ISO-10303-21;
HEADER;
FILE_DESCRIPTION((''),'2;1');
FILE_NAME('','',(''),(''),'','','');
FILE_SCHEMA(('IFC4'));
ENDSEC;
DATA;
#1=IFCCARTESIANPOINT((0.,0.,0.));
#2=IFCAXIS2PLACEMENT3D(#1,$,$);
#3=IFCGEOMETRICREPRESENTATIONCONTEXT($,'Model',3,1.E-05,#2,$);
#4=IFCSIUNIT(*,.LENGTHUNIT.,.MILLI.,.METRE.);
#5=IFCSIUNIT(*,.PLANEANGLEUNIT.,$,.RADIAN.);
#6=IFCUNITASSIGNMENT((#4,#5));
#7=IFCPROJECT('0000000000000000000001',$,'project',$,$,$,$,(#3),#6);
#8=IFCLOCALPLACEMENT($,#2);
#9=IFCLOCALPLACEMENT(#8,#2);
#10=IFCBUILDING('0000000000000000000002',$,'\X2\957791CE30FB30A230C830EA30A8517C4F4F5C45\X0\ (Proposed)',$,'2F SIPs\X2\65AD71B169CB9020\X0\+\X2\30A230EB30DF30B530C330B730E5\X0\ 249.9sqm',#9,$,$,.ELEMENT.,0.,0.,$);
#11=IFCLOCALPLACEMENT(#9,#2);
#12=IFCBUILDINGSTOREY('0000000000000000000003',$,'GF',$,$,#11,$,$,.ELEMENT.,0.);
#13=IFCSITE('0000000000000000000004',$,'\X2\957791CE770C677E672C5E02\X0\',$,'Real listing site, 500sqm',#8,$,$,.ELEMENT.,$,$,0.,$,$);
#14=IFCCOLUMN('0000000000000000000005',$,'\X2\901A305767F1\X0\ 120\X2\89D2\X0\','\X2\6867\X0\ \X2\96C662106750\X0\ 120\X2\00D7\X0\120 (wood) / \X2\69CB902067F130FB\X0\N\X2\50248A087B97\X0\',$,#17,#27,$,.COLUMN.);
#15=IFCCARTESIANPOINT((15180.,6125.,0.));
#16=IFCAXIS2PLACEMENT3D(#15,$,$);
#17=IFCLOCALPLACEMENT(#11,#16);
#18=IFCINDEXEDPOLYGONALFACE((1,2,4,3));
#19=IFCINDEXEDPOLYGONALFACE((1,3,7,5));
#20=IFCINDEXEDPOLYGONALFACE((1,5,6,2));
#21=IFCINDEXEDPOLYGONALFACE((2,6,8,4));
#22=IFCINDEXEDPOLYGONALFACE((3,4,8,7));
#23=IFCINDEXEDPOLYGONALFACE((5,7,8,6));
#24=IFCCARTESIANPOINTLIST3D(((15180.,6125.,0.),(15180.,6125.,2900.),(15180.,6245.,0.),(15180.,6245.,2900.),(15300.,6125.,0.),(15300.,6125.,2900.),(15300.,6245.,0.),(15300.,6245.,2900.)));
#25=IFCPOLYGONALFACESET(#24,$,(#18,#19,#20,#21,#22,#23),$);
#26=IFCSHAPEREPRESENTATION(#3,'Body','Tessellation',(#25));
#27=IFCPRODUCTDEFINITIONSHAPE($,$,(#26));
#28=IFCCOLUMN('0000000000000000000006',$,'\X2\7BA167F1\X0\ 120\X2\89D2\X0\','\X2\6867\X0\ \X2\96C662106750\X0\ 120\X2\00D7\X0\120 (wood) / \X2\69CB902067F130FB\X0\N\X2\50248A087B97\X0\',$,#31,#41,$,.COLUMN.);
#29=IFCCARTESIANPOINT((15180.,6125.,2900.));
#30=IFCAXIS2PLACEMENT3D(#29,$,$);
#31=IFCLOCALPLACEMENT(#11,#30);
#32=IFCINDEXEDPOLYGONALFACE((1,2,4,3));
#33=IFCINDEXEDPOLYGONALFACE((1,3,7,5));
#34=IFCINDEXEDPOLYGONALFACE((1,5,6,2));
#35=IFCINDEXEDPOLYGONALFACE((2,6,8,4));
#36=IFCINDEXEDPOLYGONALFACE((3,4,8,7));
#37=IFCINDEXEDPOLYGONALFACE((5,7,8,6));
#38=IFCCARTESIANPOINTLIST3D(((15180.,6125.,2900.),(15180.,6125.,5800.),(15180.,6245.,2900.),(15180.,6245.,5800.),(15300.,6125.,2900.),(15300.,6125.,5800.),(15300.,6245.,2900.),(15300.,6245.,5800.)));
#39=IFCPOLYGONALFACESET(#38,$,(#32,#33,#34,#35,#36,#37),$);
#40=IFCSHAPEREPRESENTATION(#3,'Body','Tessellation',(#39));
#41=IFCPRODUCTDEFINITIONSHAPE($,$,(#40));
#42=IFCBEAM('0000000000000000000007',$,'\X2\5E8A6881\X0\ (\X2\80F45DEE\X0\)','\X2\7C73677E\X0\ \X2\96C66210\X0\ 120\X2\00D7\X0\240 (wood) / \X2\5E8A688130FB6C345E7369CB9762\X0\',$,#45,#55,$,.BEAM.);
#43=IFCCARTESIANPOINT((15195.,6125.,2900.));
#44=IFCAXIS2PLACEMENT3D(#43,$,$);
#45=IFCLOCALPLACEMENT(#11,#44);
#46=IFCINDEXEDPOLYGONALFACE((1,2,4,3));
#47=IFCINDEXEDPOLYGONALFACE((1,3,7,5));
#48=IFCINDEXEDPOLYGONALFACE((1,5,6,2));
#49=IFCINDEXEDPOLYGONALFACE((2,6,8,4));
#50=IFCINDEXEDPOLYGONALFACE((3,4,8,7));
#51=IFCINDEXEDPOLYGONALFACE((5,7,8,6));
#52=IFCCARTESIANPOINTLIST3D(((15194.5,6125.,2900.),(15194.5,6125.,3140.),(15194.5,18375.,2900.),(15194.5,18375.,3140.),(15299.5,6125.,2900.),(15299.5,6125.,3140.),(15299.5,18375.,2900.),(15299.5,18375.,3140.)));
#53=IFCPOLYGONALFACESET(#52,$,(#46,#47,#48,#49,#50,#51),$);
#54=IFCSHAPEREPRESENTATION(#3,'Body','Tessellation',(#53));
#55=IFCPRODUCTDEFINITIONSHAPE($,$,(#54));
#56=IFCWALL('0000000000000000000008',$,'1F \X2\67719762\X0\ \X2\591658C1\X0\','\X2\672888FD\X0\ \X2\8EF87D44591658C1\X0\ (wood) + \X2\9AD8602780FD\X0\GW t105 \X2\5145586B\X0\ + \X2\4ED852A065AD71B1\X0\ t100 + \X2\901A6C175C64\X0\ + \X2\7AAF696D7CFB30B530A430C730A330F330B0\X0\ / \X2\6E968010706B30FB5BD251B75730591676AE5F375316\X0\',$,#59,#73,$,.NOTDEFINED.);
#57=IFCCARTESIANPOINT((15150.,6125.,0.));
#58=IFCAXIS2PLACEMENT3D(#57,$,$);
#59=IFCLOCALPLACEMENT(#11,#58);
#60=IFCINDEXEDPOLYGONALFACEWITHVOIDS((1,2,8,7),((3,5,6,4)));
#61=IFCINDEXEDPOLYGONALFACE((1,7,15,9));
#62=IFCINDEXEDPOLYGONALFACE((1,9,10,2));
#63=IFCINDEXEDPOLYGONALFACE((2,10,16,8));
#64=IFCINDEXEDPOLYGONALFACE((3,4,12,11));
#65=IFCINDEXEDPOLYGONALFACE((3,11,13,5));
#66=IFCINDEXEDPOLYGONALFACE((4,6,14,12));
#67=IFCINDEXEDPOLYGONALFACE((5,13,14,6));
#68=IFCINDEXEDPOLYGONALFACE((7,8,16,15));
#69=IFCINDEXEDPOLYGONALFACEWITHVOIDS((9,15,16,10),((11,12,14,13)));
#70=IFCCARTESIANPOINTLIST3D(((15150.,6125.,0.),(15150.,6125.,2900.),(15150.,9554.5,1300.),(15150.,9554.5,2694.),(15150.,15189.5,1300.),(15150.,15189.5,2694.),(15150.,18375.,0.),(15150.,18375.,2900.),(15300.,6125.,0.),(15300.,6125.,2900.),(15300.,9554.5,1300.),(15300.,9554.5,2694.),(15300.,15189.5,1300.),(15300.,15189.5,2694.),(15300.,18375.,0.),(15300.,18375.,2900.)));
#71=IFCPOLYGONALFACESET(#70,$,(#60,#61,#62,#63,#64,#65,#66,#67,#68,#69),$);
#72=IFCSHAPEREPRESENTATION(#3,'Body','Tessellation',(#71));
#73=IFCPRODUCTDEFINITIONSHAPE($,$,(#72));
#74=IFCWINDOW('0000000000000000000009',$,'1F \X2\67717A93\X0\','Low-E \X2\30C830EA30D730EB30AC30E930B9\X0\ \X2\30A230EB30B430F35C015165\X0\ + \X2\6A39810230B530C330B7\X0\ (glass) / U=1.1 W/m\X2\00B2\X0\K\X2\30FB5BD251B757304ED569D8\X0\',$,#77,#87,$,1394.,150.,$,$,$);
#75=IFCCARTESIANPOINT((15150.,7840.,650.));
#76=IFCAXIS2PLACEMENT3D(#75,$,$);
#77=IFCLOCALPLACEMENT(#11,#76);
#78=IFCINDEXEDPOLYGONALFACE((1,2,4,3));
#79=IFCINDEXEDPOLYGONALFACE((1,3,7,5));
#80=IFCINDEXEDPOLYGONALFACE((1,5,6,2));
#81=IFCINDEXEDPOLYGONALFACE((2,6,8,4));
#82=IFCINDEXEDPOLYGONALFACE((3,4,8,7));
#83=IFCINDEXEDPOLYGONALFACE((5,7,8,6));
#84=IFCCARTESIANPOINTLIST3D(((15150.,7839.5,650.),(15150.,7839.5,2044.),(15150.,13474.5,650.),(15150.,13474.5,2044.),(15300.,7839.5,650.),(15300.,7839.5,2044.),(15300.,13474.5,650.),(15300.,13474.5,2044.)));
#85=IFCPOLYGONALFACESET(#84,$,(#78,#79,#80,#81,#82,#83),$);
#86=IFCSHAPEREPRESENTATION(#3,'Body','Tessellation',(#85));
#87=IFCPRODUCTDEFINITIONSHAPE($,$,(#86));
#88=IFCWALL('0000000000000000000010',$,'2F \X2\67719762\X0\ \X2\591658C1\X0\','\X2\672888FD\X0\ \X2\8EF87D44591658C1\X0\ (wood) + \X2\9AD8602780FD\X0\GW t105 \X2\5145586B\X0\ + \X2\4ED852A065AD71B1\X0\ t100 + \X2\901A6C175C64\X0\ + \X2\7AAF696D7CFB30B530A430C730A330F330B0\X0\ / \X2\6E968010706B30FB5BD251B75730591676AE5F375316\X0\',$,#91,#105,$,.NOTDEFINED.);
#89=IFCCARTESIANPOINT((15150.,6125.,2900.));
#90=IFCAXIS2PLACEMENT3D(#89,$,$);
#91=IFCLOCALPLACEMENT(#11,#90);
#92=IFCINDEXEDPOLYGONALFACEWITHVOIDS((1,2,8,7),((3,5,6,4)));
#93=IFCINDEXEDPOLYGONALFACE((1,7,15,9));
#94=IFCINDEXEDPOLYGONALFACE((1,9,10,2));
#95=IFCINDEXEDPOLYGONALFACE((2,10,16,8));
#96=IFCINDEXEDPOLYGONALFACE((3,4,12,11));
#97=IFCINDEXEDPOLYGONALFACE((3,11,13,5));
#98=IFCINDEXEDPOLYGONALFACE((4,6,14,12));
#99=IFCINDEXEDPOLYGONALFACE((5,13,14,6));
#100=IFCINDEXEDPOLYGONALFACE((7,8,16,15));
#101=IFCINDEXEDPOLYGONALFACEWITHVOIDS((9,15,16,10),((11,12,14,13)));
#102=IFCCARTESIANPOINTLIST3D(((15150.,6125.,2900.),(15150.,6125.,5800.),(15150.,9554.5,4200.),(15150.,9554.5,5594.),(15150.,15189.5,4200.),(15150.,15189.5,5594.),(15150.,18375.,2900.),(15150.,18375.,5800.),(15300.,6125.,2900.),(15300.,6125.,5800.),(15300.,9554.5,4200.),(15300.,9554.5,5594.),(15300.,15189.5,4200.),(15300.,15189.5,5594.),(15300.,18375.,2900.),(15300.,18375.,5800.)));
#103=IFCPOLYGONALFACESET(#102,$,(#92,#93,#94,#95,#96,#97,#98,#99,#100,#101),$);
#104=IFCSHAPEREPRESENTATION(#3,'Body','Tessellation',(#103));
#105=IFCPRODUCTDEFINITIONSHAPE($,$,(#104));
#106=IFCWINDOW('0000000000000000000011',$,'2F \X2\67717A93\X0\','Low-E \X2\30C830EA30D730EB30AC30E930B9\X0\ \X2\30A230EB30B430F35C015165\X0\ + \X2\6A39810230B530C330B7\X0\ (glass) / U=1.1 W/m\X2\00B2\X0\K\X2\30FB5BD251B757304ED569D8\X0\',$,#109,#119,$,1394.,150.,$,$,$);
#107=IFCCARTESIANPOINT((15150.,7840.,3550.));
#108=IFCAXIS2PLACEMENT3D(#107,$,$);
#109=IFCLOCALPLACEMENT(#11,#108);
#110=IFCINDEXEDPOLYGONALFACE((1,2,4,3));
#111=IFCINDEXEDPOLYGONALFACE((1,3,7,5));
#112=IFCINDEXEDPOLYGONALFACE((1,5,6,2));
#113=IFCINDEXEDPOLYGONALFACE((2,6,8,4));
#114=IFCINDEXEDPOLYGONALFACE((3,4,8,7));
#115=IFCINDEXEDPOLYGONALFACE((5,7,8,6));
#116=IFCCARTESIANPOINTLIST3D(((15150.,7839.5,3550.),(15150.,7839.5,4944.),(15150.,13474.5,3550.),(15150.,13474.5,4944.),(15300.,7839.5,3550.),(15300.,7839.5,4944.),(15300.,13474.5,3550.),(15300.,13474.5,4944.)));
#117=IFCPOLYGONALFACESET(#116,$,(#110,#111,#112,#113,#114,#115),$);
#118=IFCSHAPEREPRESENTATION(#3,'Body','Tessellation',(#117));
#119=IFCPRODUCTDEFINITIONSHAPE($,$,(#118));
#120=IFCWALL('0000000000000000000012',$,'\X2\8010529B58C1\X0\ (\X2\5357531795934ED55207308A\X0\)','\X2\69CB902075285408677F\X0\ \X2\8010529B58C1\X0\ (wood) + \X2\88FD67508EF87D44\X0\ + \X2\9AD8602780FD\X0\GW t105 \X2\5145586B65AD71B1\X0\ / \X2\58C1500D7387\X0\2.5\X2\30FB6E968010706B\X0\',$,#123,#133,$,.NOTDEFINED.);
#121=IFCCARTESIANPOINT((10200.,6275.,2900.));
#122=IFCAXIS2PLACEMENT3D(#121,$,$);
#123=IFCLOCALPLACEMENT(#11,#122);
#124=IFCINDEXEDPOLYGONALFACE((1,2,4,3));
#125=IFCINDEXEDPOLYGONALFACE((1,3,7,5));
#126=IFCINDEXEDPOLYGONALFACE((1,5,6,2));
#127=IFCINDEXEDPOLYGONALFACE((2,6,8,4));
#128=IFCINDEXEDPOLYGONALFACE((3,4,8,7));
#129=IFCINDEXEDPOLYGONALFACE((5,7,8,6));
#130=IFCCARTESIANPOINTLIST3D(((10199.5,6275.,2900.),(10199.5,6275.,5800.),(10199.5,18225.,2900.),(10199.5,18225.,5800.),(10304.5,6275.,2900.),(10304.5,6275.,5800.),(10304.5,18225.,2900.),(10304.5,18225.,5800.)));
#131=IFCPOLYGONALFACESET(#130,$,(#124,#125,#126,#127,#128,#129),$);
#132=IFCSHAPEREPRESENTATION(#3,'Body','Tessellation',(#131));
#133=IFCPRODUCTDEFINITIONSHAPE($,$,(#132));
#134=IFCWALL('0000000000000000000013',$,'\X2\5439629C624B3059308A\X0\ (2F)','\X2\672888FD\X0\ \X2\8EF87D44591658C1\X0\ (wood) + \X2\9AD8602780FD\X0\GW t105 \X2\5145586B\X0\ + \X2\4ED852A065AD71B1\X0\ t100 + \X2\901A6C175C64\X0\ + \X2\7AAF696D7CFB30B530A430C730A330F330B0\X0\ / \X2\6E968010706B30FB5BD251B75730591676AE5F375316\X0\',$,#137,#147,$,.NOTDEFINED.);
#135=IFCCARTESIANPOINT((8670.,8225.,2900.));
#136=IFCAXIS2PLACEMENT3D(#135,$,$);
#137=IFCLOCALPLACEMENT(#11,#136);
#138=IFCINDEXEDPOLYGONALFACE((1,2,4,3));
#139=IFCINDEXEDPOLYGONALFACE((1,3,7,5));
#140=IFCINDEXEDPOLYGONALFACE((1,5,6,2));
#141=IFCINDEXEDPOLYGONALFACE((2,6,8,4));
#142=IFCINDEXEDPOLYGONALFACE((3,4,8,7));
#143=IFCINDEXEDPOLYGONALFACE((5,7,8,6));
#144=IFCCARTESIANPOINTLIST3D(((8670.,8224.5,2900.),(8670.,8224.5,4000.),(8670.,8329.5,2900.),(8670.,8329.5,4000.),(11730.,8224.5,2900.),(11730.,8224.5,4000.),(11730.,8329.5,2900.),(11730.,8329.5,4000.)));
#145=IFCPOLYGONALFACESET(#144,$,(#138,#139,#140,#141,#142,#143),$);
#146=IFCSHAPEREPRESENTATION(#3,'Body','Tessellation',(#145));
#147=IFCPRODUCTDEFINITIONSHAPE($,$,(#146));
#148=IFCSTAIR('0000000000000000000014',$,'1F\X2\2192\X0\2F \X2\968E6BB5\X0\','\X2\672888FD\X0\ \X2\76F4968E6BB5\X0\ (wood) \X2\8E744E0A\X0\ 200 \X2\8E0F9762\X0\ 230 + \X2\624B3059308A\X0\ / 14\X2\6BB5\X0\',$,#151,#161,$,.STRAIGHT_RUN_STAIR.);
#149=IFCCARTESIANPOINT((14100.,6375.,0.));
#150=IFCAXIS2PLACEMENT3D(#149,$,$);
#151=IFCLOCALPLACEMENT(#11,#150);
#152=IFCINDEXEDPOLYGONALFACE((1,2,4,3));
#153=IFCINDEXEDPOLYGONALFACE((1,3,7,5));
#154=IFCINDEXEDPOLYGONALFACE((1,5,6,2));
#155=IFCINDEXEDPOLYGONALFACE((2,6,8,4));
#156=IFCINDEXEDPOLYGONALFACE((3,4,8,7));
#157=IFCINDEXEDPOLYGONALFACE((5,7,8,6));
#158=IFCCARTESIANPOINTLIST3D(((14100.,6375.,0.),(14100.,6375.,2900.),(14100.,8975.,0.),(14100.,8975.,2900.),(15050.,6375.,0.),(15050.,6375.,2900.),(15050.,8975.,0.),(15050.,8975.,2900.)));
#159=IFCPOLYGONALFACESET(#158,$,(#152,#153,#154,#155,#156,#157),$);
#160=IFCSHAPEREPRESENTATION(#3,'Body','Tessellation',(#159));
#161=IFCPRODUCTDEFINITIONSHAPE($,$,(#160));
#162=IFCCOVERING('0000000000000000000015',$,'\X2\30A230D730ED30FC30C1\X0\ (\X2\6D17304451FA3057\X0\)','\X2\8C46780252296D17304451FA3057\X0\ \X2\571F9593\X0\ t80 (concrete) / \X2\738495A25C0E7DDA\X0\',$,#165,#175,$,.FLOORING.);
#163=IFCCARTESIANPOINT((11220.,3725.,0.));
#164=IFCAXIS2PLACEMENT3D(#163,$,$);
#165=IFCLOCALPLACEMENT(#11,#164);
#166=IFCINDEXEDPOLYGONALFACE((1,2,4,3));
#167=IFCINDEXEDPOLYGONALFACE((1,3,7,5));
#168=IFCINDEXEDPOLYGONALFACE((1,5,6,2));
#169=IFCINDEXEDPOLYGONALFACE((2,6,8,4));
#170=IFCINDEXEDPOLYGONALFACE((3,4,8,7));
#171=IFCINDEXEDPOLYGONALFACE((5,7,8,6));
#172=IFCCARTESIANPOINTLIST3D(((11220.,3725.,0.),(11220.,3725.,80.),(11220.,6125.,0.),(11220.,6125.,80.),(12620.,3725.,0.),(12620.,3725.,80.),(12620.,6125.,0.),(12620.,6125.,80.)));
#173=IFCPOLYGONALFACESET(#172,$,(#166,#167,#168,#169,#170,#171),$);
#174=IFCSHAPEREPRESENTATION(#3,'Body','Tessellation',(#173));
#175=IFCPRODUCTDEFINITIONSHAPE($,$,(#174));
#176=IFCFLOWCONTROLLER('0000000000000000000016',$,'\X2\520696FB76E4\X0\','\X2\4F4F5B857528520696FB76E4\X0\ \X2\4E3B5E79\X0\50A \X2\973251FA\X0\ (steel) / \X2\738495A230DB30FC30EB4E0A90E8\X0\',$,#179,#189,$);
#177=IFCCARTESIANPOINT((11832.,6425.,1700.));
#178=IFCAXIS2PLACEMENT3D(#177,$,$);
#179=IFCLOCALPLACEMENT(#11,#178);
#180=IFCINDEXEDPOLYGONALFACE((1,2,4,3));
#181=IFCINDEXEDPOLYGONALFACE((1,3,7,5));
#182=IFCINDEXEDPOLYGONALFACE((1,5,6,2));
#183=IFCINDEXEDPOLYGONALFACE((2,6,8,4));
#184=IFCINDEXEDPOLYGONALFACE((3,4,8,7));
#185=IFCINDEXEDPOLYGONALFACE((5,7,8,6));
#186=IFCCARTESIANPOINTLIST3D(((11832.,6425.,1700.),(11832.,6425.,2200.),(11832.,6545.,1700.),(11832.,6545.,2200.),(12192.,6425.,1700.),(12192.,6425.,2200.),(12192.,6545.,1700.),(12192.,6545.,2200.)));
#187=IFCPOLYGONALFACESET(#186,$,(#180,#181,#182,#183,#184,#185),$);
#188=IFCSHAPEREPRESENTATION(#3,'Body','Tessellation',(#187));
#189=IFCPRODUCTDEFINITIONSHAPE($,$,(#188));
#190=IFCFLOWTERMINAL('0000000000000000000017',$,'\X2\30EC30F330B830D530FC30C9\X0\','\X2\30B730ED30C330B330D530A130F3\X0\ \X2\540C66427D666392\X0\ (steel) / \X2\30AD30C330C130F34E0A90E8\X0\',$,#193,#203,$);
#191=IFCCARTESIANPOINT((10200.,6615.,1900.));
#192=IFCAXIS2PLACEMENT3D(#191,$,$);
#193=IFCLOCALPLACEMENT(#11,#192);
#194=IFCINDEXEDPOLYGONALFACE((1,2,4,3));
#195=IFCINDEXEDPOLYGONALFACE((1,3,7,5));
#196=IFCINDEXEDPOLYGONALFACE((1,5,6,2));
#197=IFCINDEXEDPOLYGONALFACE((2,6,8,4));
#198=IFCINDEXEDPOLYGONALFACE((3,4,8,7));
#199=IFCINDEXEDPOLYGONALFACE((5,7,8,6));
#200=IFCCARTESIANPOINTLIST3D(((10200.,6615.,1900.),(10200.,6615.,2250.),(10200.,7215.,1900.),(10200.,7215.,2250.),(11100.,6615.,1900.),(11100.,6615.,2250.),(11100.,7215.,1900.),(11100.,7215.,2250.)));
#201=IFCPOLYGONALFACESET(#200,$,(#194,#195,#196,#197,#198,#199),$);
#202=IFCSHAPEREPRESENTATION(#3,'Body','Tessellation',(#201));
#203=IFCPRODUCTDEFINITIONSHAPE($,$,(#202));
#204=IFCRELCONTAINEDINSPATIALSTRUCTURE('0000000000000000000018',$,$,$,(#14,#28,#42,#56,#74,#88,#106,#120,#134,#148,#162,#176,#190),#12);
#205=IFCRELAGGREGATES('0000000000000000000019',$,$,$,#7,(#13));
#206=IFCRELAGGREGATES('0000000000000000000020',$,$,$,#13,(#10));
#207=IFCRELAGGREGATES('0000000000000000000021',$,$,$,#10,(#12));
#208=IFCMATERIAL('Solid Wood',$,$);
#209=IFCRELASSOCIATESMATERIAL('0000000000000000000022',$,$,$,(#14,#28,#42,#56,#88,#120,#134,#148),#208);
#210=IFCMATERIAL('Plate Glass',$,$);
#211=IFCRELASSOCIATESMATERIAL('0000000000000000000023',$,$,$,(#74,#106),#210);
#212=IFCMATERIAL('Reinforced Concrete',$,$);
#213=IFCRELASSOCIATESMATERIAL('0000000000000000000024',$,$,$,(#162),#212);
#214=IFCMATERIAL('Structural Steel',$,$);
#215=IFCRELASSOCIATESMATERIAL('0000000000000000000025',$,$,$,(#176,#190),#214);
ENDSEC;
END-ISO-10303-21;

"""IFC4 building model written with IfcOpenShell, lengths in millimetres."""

from ifc_helpers import new_model, si_unit, frame, frame_2d, origin, place, context, project, spatial, rectangle, extrude, material, element, fill, save


model = new_model("IFC4")

# Units and contexts
model_context = context("Model", 3, precision=1e-05, world=origin())
ifc_project = project(units=[si_unit("LENGTHUNIT", "METRE", prefix="MILLI"), si_unit("PLANEANGLEUNIT", "RADIAN")], contexts=[model_context])

# Site, building, storey
site_placement = place(None, origin())
site = spatial("IfcSite", under=ifc_project, at=site_placement, Name="長野県松本市", ObjectType="Real listing site, 500sqm", CompositionType="ELEMENT", RefElevation=0.0)
building_placement = place(site_placement, origin())
building = spatial("IfcBuilding", under=site, at=building_placement, Name="長野・アトリエ兼住居 (Proposed)", ObjectType="2F SIPs断熱構造+アルミサッシュ 249.9sqm", CompositionType="ELEMENT", ElevationOfRefHeight=0.0, ElevationOfTerrain=0.0)
storey_placement = place(building_placement, origin())
storey = spatial("IfcBuildingStorey", under=building, at=storey_placement, Name="GF", CompositionType="ELEMENT", Elevation=0.0)

# Columns
ifc_material_1 = material(Name="Solid Wood")
column_1_placement = place(storey_placement, frame((15180.0, 6125.0, 0.0)))
element("IfcColumn", 1, at=column_1_placement, inside=storey, material=ifc_material_1, Name="通し柱 120角", Description="桧 集成材 120×120 (wood) / 構造柱・N値計算", PredefinedType="COLUMN", context=model_context, shape_type="SweptSolid", body=[
    extrude(rectangle(XDim=120.0, YDim=120.0, at=frame_2d((60.0, 60.0))), frame((15180.0, 6125.0, 0.0)), (0.0, 0.0, 1.0), 2900.0),
])
column_2_placement = place(storey_placement, frame((15180.0, 6125.0, 2900.0)))
element("IfcColumn", 2, at=column_2_placement, inside=storey, material=ifc_material_1, Name="管柱 120角", Description="桧 集成材 120×120 (wood) / 構造柱・N値計算", PredefinedType="COLUMN", context=model_context, shape_type="SweptSolid", body=[
    extrude(rectangle(XDim=120.0, YDim=120.0, at=frame_2d((60.0, 60.0))), frame((15180.0, 6125.0, 2900.0)), (0.0, 0.0, 1.0), 2900.0),
])

# Beam
beam_1_placement = place(storey_placement, frame((15195.0, 6125.0, 2900.0)))
element("IfcBeam", 3, at=beam_1_placement, inside=storey, material=ifc_material_1, Name="床梁 (胴差)", Description="米松 集成 120×240 (wood) / 床梁・水平構面", PredefinedType="BEAM", context=model_context, shape_type="SweptSolid", body=[
    extrude(rectangle(XDim=105.0, YDim=12250.0, at=frame_2d((52.0, 6125.0))), frame((15195.0, 6125.0, 2900.0)), (0.0, 0.0, 1.0), 240.0),
])

# Wall, opening, window
wall_1_placement = place(storey_placement, frame((15150.0, 6125.0, 0.0)))
wall_1 = element("IfcWall", 4, at=wall_1_placement, inside=storey, material=ifc_material_1, Name="1F 東面 外壁", Description="木製 軸組外壁 (wood) + 高性能GW t105 充填 + 付加断熱 t100 + 通気層 + 窯業系サイディング / 準耐火・寒冷地外皮強化", PredefinedType="NOTDEFINED", context=model_context, shape_type="SweptSolid", body=[
    extrude(rectangle(XDim=150.0, YDim=12250.0, at=frame_2d((75.0, 6125.0))), frame((15150.0, 6125.0, 0.0)), (0.0, 0.0, 1.0), 2900.0),
])
opening_1_placement = place(storey_placement, frame((15150.0, 7840.0, 650.0)))
opening_1 = element("IfcOpeningElement", 5, at=opening_1_placement, cuts=wall_1, PredefinedType="NOTDEFINED", context=model_context, shape_type="SweptSolid", body=[
    extrude(rectangle(XDim=150.0, YDim=5635.0, at=frame_2d((75.0, 2817.0))), frame((15150.0, 7840.0, 650.0)), (0.0, 0.0, 1.0), 1394.0),
])
ifc_material_2 = material(Name="Plate Glass")
window_1_placement = place(storey_placement, frame((15150.0, 7840.0, 650.0)))
window_1 = element("IfcWindow", 6, at=window_1_placement, inside=storey, material=ifc_material_2, Name="1F 東窓", Description="Low-E トリプルガラス アルゴン封入 + 樹脂サッシ (glass) / U=1.1 W/m²K・寒冷地仕様", OverallHeight=1394.0, OverallWidth=150.0, context=model_context, shape_type="SweptSolid", body=[
    extrude(rectangle(XDim=150.0, YDim=5635.0, at=frame_2d((75.0, 2817.0))), frame((15150.0, 7840.0, 650.0)), (0.0, 0.0, 1.0), 1394.0),
])
fill(opening_1, window_1)

# Wall, opening, window
wall_2_placement = place(storey_placement, frame((15150.0, 6125.0, 2900.0)))
wall_2 = element("IfcWall", 7, at=wall_2_placement, inside=storey, material=ifc_material_1, Name="2F 東面 外壁", Description="木製 軸組外壁 (wood) + 高性能GW t105 充填 + 付加断熱 t100 + 通気層 + 窯業系サイディング / 準耐火・寒冷地外皮強化", PredefinedType="NOTDEFINED", context=model_context, shape_type="SweptSolid", body=[
    extrude(rectangle(XDim=150.0, YDim=12250.0, at=frame_2d((75.0, 6125.0))), frame((15150.0, 6125.0, 2900.0)), (0.0, 0.0, 1.0), 2900.0),
])
opening_2_placement = place(storey_placement, frame((15150.0, 7840.0, 3550.0)))
opening_2 = element("IfcOpeningElement", 8, at=opening_2_placement, cuts=wall_2, PredefinedType="NOTDEFINED", context=model_context, shape_type="SweptSolid", body=[
    extrude(rectangle(XDim=150.0, YDim=5635.0, at=frame_2d((75.0, 2817.0))), frame((15150.0, 7840.0, 3550.0)), (0.0, 0.0, 1.0), 1394.0),
])
window_2_placement = place(storey_placement, frame((15150.0, 7840.0, 3550.0)))
window_2 = element("IfcWindow", 9, at=window_2_placement, inside=storey, material=ifc_material_2, Name="2F 東窓", Description="Low-E トリプルガラス アルゴン封入 + 樹脂サッシ (glass) / U=1.1 W/m²K・寒冷地仕様", OverallHeight=1394.0, OverallWidth=150.0, context=model_context, shape_type="SweptSolid", body=[
    extrude(rectangle(XDim=150.0, YDim=5635.0, at=frame_2d((75.0, 2817.0))), frame((15150.0, 7840.0, 3550.0)), (0.0, 0.0, 1.0), 1394.0),
])
fill(opening_2, window_2)

# Walls
wall_3_placement = place(storey_placement, frame((10200.0, 6275.0, 2900.0)))
element("IfcWall", 10, at=wall_3_placement, inside=storey, material=ifc_material_1, Name="耐力壁 (南北間仕切り)", Description="構造用合板 耐力壁 (wood) + 製材軸組 + 高性能GW t105 充填断熱 / 壁倍率2.5・準耐火", PredefinedType="NOTDEFINED", context=model_context, shape_type="SweptSolid", body=[
    extrude(rectangle(XDim=105.0, YDim=11950.0, at=frame_2d((52.0, 5975.0))), frame((10200.0, 6275.0, 2900.0)), (0.0, 0.0, 1.0), 2900.0),
])
wall_4_placement = place(storey_placement, frame((8670.0, 8225.0, 2900.0)))
element("IfcWall", 11, at=wall_4_placement, inside=storey, material=ifc_material_1, Name="吹抜手すり (2F)", Description="木製 軸組外壁 (wood) + 高性能GW t105 充填 + 付加断熱 t100 + 通気層 + 窯業系サイディング / 準耐火・寒冷地外皮強化", PredefinedType="NOTDEFINED", context=model_context, shape_type="SweptSolid", body=[
    extrude(rectangle(XDim=3060.0, YDim=105.0, at=frame_2d((1530.0, 52.0))), frame((8670.0, 8225.0, 2900.0)), (0.0, 0.0, 1.0), 1100.0),
])

# Stair
stair_placement = place(storey_placement, frame((14100.0, 6375.0, 0.0)))
element("IfcStair", 12, at=stair_placement, inside=storey, material=ifc_material_1, Name="1F→2F 階段", Description="木製 直階段 (wood) 蹴上 200 踏面 230 + 手すり / 14段", PredefinedType="STRAIGHT_RUN_STAIR", context=model_context, shape_type="SweptSolid", body=[
    extrude(rectangle(XDim=950.0, YDim=2600.0, at=frame_2d((475.0, 1300.0))), frame((14100.0, 6375.0, 0.0)), (0.0, 0.0, 1.0), 2900.0),
])

# Covering
ifc_material_3 = material(Name="Reinforced Concrete")
covering_placement = place(storey_placement, frame((11220.0, 3725.0, 0.0)))
element("IfcCovering", 13, at=covering_placement, inside=storey, material=ifc_material_3, Name="アプローチ (洗い出し)", Description="豆砂利洗い出し 土間 t80 (concrete) / 玄関導線", PredefinedType="FLOORING", context=model_context, shape_type="SweptSolid", body=[
    extrude(rectangle(XDim=1400.0, YDim=2400.0, at=frame_2d((700.0, 1200.0))), frame((11220.0, 3725.0, 0.0)), (0.0, 0.0, 1.0), 80.0),
])

# Flow controller
ifc_material_4 = material(Name="Structural Steel")
flow_controller_placement = place(storey_placement, frame((11832.0, 6425.0, 1700.0)))
element("IfcFlowController", 14, at=flow_controller_placement, inside=storey, material=ifc_material_4, Name="分電盤", Description="住宅用分電盤 主幹50A 露出 (steel) / 玄関ホール上部", context=model_context, shape_type="SweptSolid", body=[
    extrude(rectangle(XDim=360.0, YDim=120.0, at=frame_2d((180.0, 60.0))), frame((11832.0, 6425.0, 1700.0)), (0.0, 0.0, 1.0), 500.0),
])

# Flow terminal
flow_terminal_1_placement = place(storey_placement, frame((10200.0, 6615.0, 1900.0)))
element("IfcFlowTerminal", 15, at=flow_terminal_1_placement, inside=storey, material=ifc_material_4, Name="レンジフード", Description="シロッコファン 同時給排 (steel) / キッチン上部", context=model_context, shape_type="SweptSolid", body=[
    extrude(rectangle(XDim=900.0, YDim=600.0, at=frame_2d((450.0, 300.0))), frame((10200.0, 6615.0, 1900.0)), (0.0, 0.0, 1.0), 350.0),
])

save(model, "model.ifc")
